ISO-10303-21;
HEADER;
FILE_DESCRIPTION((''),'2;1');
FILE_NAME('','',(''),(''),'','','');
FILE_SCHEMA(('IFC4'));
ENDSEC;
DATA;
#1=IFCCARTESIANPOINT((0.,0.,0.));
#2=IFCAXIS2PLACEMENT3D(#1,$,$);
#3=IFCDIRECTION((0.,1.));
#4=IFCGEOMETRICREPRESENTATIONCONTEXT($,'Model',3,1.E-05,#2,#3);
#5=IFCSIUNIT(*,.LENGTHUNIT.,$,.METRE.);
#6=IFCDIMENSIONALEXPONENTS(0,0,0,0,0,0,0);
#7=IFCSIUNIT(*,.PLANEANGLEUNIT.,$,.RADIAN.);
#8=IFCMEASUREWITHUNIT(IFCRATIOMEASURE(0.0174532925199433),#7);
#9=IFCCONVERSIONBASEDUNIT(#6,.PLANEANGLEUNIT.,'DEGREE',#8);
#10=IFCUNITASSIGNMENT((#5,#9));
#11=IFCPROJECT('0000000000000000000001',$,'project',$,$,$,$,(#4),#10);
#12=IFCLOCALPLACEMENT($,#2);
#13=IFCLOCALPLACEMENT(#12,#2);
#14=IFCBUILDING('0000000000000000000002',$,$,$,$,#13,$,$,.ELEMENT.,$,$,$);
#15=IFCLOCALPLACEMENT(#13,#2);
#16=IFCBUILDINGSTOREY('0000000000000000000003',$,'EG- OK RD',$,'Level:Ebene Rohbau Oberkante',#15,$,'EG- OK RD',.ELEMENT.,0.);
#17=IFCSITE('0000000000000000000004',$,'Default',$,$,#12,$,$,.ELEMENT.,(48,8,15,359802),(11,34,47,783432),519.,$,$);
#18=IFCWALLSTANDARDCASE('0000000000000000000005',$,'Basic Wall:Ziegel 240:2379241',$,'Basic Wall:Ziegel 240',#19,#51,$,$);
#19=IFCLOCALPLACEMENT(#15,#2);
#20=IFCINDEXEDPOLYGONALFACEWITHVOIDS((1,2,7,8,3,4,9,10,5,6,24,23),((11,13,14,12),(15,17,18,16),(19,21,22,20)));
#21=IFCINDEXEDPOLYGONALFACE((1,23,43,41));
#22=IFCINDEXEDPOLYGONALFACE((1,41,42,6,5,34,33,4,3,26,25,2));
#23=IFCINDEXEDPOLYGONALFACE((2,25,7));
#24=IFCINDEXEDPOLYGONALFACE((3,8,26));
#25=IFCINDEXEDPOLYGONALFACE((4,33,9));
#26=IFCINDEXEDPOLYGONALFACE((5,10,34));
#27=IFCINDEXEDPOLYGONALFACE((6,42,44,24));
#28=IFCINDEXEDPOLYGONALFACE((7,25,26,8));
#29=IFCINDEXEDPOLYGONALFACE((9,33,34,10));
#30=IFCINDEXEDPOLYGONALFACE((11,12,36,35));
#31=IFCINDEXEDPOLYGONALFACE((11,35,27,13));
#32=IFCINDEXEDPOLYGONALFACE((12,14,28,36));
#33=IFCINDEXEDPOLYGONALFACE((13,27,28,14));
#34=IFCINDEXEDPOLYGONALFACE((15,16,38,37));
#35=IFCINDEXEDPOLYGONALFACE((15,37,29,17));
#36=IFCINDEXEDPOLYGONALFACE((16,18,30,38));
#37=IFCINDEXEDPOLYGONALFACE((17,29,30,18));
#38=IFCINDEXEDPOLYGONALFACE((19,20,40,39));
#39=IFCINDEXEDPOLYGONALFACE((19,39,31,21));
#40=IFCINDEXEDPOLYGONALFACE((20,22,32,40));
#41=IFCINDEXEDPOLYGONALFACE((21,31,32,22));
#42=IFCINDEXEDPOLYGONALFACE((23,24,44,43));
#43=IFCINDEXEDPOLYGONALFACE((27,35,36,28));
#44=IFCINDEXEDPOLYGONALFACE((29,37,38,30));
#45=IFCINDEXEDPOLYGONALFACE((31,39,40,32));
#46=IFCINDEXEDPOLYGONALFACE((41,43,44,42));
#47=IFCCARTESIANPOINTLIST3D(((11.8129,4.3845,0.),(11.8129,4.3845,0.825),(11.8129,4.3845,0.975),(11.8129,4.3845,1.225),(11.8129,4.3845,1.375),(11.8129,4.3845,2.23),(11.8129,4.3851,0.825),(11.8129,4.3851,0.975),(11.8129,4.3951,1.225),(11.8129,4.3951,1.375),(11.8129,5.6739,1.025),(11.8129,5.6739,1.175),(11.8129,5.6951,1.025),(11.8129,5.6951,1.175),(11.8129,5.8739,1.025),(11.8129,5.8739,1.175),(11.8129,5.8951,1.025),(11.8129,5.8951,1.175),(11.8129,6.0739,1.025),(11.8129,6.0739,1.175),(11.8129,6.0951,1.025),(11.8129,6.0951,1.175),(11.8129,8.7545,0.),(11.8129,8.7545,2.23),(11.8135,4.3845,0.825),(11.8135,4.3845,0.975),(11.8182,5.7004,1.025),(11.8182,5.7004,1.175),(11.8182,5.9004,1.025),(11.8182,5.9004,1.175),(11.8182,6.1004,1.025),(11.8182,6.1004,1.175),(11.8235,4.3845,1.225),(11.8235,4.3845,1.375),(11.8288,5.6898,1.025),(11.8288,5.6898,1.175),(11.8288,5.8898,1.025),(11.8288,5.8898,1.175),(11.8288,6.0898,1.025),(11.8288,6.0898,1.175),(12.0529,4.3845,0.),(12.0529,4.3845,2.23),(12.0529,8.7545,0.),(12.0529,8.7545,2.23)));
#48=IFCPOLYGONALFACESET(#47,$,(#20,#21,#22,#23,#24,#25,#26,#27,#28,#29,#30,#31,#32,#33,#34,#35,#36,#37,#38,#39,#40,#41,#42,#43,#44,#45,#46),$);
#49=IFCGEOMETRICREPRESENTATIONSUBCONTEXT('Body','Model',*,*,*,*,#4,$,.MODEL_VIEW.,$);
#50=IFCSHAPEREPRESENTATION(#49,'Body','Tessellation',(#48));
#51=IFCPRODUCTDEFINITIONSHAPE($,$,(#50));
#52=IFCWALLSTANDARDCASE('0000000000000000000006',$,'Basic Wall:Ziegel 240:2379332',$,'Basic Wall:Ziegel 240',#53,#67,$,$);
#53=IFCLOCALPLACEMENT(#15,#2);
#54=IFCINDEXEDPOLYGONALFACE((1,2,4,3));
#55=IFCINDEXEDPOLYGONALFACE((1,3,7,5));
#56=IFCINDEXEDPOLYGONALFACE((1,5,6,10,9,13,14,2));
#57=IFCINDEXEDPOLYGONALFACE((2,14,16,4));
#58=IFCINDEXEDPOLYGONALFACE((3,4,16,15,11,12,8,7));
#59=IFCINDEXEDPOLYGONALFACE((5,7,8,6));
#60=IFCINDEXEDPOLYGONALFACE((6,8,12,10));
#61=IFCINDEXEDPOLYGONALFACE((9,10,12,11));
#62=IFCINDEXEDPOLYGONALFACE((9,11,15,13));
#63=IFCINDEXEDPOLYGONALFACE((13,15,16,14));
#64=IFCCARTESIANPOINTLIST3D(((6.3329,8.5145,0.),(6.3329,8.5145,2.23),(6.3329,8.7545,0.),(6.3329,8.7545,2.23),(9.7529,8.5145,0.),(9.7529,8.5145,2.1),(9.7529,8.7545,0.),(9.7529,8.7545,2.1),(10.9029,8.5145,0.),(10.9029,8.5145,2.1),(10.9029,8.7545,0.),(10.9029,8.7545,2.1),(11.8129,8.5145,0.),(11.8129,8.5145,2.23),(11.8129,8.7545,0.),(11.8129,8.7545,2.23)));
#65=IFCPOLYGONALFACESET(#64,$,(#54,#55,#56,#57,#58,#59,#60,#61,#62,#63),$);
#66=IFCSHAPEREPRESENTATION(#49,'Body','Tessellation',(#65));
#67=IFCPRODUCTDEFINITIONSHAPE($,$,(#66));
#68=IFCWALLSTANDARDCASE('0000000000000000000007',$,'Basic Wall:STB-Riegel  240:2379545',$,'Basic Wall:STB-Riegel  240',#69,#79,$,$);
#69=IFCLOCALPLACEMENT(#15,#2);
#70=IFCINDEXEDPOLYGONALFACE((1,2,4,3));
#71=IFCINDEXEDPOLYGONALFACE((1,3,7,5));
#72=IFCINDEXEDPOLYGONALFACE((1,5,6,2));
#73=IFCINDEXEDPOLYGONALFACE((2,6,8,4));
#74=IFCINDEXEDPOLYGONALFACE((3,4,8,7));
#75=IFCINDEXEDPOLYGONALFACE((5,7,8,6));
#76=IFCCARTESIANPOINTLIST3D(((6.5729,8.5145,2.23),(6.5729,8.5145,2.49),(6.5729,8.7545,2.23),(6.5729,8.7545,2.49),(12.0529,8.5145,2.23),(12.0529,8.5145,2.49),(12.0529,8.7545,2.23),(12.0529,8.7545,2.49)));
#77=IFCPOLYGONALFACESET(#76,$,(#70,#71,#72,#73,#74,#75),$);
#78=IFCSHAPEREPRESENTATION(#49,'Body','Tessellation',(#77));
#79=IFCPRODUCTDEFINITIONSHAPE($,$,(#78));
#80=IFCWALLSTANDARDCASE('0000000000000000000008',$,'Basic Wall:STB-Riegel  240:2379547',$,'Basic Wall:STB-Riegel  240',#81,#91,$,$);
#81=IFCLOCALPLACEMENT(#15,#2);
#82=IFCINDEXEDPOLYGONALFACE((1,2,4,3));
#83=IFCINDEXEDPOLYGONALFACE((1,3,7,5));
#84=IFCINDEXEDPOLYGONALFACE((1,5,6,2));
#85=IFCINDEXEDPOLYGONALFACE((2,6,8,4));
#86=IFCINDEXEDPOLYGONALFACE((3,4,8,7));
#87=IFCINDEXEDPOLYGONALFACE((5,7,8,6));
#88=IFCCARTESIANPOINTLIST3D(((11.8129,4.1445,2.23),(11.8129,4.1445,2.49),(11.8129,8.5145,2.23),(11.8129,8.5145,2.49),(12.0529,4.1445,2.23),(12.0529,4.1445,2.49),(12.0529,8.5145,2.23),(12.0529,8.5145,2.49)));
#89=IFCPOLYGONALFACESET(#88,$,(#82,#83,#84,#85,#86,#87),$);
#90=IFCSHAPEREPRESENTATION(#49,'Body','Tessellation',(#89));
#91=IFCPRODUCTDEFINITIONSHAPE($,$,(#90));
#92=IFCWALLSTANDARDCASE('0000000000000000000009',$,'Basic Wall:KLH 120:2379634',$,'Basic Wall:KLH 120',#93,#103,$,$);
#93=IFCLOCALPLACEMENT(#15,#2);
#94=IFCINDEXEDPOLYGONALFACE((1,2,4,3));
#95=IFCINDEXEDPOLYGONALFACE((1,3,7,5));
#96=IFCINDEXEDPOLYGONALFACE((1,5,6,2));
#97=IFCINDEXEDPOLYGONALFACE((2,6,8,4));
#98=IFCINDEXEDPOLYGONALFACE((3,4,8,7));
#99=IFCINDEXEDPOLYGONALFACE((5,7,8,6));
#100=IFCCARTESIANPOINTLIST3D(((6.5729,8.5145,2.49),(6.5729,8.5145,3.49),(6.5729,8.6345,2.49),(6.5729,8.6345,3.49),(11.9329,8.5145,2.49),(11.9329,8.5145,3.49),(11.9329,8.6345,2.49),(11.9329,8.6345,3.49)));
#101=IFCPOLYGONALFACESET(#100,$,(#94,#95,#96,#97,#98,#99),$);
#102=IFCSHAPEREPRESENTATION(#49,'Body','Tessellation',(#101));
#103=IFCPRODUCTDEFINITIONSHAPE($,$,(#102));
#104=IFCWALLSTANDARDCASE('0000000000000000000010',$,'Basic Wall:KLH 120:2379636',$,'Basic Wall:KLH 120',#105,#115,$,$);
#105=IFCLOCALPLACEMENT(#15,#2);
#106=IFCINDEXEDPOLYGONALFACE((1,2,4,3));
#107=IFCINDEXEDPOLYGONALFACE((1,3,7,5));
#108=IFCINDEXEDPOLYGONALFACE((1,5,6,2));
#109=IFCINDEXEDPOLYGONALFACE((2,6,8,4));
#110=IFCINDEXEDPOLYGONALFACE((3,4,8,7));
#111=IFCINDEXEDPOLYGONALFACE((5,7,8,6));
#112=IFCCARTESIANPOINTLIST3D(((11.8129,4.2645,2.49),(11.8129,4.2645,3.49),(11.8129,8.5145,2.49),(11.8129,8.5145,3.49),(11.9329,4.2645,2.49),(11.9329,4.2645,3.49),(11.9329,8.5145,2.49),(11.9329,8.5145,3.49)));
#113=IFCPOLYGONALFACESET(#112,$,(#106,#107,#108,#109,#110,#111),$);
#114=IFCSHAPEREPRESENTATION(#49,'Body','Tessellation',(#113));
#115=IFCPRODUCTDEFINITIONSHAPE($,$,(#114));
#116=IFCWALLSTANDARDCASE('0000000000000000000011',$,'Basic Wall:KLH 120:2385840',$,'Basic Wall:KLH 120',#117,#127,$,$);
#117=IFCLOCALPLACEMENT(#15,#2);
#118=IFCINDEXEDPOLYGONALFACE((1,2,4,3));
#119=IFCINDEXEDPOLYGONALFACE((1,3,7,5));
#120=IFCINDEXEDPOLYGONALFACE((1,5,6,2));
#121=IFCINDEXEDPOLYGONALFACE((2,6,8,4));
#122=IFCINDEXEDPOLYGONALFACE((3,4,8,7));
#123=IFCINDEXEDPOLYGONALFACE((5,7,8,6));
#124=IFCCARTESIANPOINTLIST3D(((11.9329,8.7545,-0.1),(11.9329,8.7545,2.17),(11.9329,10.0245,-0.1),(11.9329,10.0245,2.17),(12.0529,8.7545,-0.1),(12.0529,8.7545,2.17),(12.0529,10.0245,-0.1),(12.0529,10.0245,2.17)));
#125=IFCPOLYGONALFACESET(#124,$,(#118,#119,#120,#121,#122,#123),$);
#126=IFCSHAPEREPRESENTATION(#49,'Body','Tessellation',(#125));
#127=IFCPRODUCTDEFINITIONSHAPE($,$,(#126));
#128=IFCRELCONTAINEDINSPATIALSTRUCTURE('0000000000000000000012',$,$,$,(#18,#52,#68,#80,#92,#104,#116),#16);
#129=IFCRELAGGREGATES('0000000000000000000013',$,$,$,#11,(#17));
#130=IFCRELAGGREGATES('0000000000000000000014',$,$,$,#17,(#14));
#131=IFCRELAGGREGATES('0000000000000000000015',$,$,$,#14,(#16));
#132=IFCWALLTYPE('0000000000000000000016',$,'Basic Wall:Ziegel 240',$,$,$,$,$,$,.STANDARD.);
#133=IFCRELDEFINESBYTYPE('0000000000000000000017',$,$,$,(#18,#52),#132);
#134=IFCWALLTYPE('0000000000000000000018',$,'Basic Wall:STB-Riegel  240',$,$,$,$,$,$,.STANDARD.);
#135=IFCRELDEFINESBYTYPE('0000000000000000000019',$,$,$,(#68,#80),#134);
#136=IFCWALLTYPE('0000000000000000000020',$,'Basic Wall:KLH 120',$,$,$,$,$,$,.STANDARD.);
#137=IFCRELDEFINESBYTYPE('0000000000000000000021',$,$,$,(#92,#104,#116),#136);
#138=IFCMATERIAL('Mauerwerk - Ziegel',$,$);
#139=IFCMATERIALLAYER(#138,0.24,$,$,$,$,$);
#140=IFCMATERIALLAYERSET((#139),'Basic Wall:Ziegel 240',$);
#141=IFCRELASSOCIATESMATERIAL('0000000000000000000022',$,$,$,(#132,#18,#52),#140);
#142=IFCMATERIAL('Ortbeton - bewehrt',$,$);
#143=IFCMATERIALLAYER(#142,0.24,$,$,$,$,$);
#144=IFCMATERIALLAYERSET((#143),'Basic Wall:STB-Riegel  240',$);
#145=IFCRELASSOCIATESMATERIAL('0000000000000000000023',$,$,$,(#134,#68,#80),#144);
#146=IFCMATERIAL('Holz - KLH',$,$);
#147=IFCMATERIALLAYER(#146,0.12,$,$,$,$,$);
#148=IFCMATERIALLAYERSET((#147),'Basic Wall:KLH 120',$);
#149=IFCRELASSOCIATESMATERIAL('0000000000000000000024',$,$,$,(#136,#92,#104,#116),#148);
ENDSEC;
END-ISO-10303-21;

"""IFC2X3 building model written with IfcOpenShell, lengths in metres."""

from ifc_helpers import new_model, entity, si_unit, converted_unit, direction, frame, frame_2d, origin, place, context, subcontext, project, spatial, polyline, rectangle, extrude, clip, bounded_halfspace, material, layer, layer_set, layer_usage, type_object, element, save


model = new_model("IFC2X3")

# Units and contexts
model_context = context("Model", 3, precision=1e-05, world=origin(), true_north=direction((0.0, 1.0)))
body_context = subcontext(model_context, "Body", "Model", "MODEL_VIEW")
ifc_project = project(units=[si_unit("LENGTHUNIT", "METRE"), converted_unit("PLANEANGLEUNIT", "DEGREE", entity("IfcRatioMeasure", 0.0174532925199433), si_unit("PLANEANGLEUNIT", "RADIAN"), dimensions=[0, 0, 0, 0, 0, 0, 0])], contexts=[model_context])

# Site, building, storey
site_placement = place(None, origin())
site = spatial("IfcSite", under=ifc_project, at=site_placement, Name="Default", CompositionType="ELEMENT", RefLatitude=(48, 8, 15, 359802), RefLongitude=(11, 34, 47, 783432), RefElevation=519.0)
building_placement = place(site_placement, origin())
building = spatial("IfcBuilding", under=site, at=building_placement, CompositionType="ELEMENT")
storey_placement = place(building_placement, origin())
storey = spatial("IfcBuildingStorey", under=building, at=storey_placement, Name="EG- OK RD", ObjectType="Level:Ebene Rohbau Oberkante", LongName="EG- OK RD", CompositionType="ELEMENT", Elevation=0.0)

# Wall, openings
ifc_material_1 = material(Name="Mauerwerk - Ziegel")
ifc_layer_1 = layer(ifc_material_1, 0.24)
ifc_layer_set_1 = layer_set([ifc_layer_1], Name="Basic Wall:Ziegel 240")
ifc_layer_usage_1 = layer_usage(ifc_layer_set_1, "AXIS2", "POSITIVE", -0.12)
wall_type_1 = type_object("IfcWallType", Name="Basic Wall:Ziegel 240", PredefinedType="STANDARD", material=ifc_layer_set_1)
wall_1_placement = place(storey_placement, frame((11.9329, 4.3845, 0.0), z_axis=(0.0, 0.0, 1.0), x_axis=(0.0, 1.0, 0.0)))
wall_1 = element("IfcWallStandardCase", 1, at=wall_1_placement, inside=storey, type_object=wall_type_1, material=ifc_layer_usage_1, Name="Basic Wall:Ziegel 240:2379241", ObjectType="Basic Wall:Ziegel 240", context=body_context, shape_type="SweptSolid", body=[
    extrude(rectangle(XDim=4.37, YDim=0.24, at=frame_2d((2.185, 0.0), x_axis=(-1.0, 0.0))), origin(), (0.0, 0.0, 1.0), 2.23),
])
opening_1_placement = place(wall_1_placement, origin())
element("IfcOpeningElement", 2, at=opening_1_placement, cuts=wall_1, ObjectType="Recess", context=body_context, shape_type="SweptSolid", body=[
    extrude(rectangle(XDim=0.15, YDim=0.0285, at=frame_2d((0.0, 0.0), x_axis=(0.0, 1.0))), frame((0.0048, 0.1242, 0.9), z_axis=(-0.707107, 0.707107, 0.0), x_axis=(-0.707107, -0.707107, 0.0)), (0.0, 0.0, 1.0), 0.015),
])
opening_2_placement = place(wall_1_placement, origin())
element("IfcOpeningElement", 3, at=opening_2_placement, cuts=wall_1, ObjectType="Recess", context=body_context, shape_type="SweptSolid", body=[
    extrude(rectangle(XDim=0.15, YDim=0.0285, at=frame_2d((0.0, 0.0), x_axis=(0.0, 1.0))), frame((0.0048, 0.1142, 1.3), z_axis=(-0.707107, 0.707107, 0.0), x_axis=(-0.707107, -0.707107, 0.0)), (0.0, 0.0, 1.0), 0.015),
])
opening_3_placement = place(wall_1_placement, origin())
element("IfcOpeningElement", 4, at=opening_3_placement, cuts=wall_1, ObjectType="Recess", context=body_context, shape_type="SweptSolid", body=[
    extrude(rectangle(XDim=0.15, YDim=0.0285, at=frame_2d((0.0, 0.0), x_axis=(0.0, 1.0))), frame((0.1195, 0.2289, 1.1), z_axis=(-0.707107, 0.707107, 0.0), x_axis=(-0.707107, -0.707107, 0.0)), (0.0, 0.0, 1.0), 0.015),
])
opening_4_placement = place(wall_1_placement, origin())
element("IfcOpeningElement", 5, at=opening_4_placement, cuts=wall_1, ObjectType="Recess", context=body_context, shape_type="SweptSolid", body=[
    extrude(rectangle(XDim=0.15, YDim=0.0285, at=frame_2d((0.0, 0.0), x_axis=(0.0, 1.0))), frame((1.2952, 0.1142, 1.1), z_axis=(0.707107, 0.707107, 0.0), x_axis=(0.707107, -0.707107, 0.0)), (0.0, 0.0, 1.0), 0.015),
])
opening_5_placement = place(wall_1_placement, origin())
element("IfcOpeningElement", 6, at=opening_5_placement, cuts=wall_1, ObjectType="Recess", context=body_context, shape_type="SweptSolid", body=[
    extrude(rectangle(XDim=0.15, YDim=0.0285, at=frame_2d((0.0, 0.0), x_axis=(0.0, 1.0))), frame((1.4952, 0.1142, 1.1), z_axis=(0.707107, 0.707107, 0.0), x_axis=(0.707107, -0.707107, 0.0)), (0.0, 0.0, 1.0), 0.015),
])
opening_6_placement = place(wall_1_placement, origin())
element("IfcOpeningElement", 7, at=opening_6_placement, cuts=wall_1, ObjectType="Recess", context=body_context, shape_type="SweptSolid", body=[
    extrude(rectangle(XDim=0.15, YDim=0.0285, at=frame_2d((0.0, 0.0), x_axis=(0.0, 1.0))), frame((1.6952, 0.1142, 1.1), z_axis=(0.707107, 0.707107, 0.0), x_axis=(0.707107, -0.707107, 0.0)), (0.0, 0.0, 1.0), 0.015),
])

# Wall, opening
ifc_layer_usage_2 = layer_usage(ifc_layer_set_1, "AXIS2", "POSITIVE", -0.12)
wall_2_placement = place(storey_placement, frame((11.8129, 8.6345, 0.0), z_axis=(0.0, 0.0, 1.0), x_axis=(-1.0, 0.0, 0.0)))
wall_2 = element("IfcWallStandardCase", 8, at=wall_2_placement, inside=storey, type_object=wall_type_1, material=ifc_layer_usage_2, Name="Basic Wall:Ziegel 240:2379332", ObjectType="Basic Wall:Ziegel 240", context=body_context, shape_type="SweptSolid", body=[
    extrude(rectangle(XDim=5.48, YDim=0.24, at=frame_2d((2.74, 0.0), x_axis=(-1.0, 0.0))), origin(), (0.0, 0.0, 1.0), 2.23),
])
opening_7_placement = place(wall_2_placement, frame((0.91, -0.12, 0.0)))
element("IfcOpeningElement", 9, at=opening_7_placement, cuts=wall_2, ObjectType="Opening", context=body_context, shape_type="SweptSolid", body=[
    extrude(rectangle(XDim=2.1, YDim=1.15, at=frame_2d((1.05, 0.575), x_axis=(-1.0, 0.0))), frame((0.0, 0.0, 0.0), z_axis=(0.0, 1.0, 0.0), x_axis=(0.0, 0.0, 1.0)), (0.0, 0.0, 1.0), 0.24),
])

# Walls
ifc_material_2 = material(Name="Ortbeton - bewehrt")
ifc_layer_2 = layer(ifc_material_2, 0.24)
ifc_layer_set_2 = layer_set([ifc_layer_2], Name="Basic Wall:STB-Riegel  240")
ifc_layer_usage_3 = layer_usage(ifc_layer_set_2, "AXIS2", "NEGATIVE", 0.12)
wall_type_2 = type_object("IfcWallType", Name="Basic Wall:STB-Riegel  240", PredefinedType="STANDARD", material=ifc_layer_set_2)
wall_3_placement = place(storey_placement, frame((12.0529, 8.6345, 2.23), z_axis=(0.0, 0.0, 1.0), x_axis=(-1.0, 0.0, 0.0)))
element("IfcWallStandardCase", 10, at=wall_3_placement, inside=storey, type_object=wall_type_2, material=ifc_layer_usage_3, Name="Basic Wall:STB-Riegel  240:2379545", ObjectType="Basic Wall:STB-Riegel  240", context=body_context, shape_type="SweptSolid", body=[
    extrude(rectangle(XDim=5.48, YDim=0.24, at=frame_2d((2.74, 0.0), x_axis=(-1.0, 0.0))), origin(), (0.0, 0.0, 1.0), 0.26),
])
ifc_layer_usage_4 = layer_usage(ifc_layer_set_2, "AXIS2", "NEGATIVE", 0.12)
wall_4_placement = place(storey_placement, frame((11.9329, 4.1445, 2.23), z_axis=(0.0, 0.0, 1.0), x_axis=(0.0, 1.0, 0.0)))
element("IfcWallStandardCase", 11, at=wall_4_placement, inside=storey, type_object=wall_type_2, material=ifc_layer_usage_4, Name="Basic Wall:STB-Riegel  240:2379547", ObjectType="Basic Wall:STB-Riegel  240", context=body_context, shape_type="SweptSolid", body=[
    extrude(rectangle(XDim=4.37, YDim=0.24, at=frame_2d((2.185, 0.0), x_axis=(-1.0, 0.0))), origin(), (0.0, 0.0, 1.0), 0.26),
])
ifc_material_3 = material(Name="Holz - KLH")
ifc_layer_3 = layer(ifc_material_3, 0.12)
ifc_layer_set_3 = layer_set([ifc_layer_3], Name="Basic Wall:KLH 120")
ifc_layer_usage_5 = layer_usage(ifc_layer_set_3, "AXIS2", "NEGATIVE", 0.06)
wall_type_3 = type_object("IfcWallType", Name="Basic Wall:KLH 120", PredefinedType="STANDARD", material=ifc_layer_set_3)
wall_5_placement = place(storey_placement, frame((11.9329, 8.5745, 2.49), z_axis=(0.0, 0.0, 1.0), x_axis=(-1.0, 0.0, 0.0)))
element("IfcWallStandardCase", 12, at=wall_5_placement, inside=storey, type_object=wall_type_3, material=ifc_layer_usage_5, Name="Basic Wall:KLH 120:2379634", ObjectType="Basic Wall:KLH 120", context=body_context, shape_type="SweptSolid", body=[
    extrude(rectangle(XDim=5.36, YDim=0.12, at=frame_2d((2.68, 0.0), x_axis=(-1.0, 0.0))), origin(), (0.0, 0.0, 1.0), 1.0),
])
ifc_layer_usage_6 = layer_usage(ifc_layer_set_3, "AXIS2", "NEGATIVE", 0.06)
wall_6_placement = place(storey_placement, frame((11.8729, 4.2645, 2.49), z_axis=(0.0, 0.0, 1.0), x_axis=(0.0, 1.0, 0.0)))
element("IfcWallStandardCase", 13, at=wall_6_placement, inside=storey, type_object=wall_type_3, material=ifc_layer_usage_6, Name="Basic Wall:KLH 120:2379636", ObjectType="Basic Wall:KLH 120", context=body_context, shape_type="SweptSolid", body=[
    extrude(rectangle(XDim=4.25, YDim=0.12, at=frame_2d((2.125, 0.0), x_axis=(-1.0, 0.0))), origin(), (0.0, 0.0, 1.0), 1.0),
])
ifc_layer_usage_7 = layer_usage(ifc_layer_set_3, "AXIS2", "POSITIVE", -0.06)
wall_7_placement = place(storey_placement, frame((11.9929, 8.7545, -0.1), z_axis=(0.0, 0.0, 1.0), x_axis=(0.0, 1.0, 0.0)))
element("IfcWallStandardCase", 14, at=wall_7_placement, inside=storey, type_object=wall_type_3, material=ifc_layer_usage_7, Name="Basic Wall:KLH 120:2385840", ObjectType="Basic Wall:KLH 120", context=body_context, shape_type="Clipping", body=[
    clip(extrude(rectangle(XDim=1.27, YDim=0.12, at=frame_2d((0.635, 0.0), x_axis=(-1.0, 0.0))), origin(), (0.0, 0.0, 1.0), 2.27), bounded_halfspace(frame((0.0, -0.06, 2.27), z_axis=(0.0, 0.0, -1.0), x_axis=(-1.0, 0.0, 0.0)), True, frame((0.0, -0.06, 2.27)), polyline([(0.0, 0.0), (1.27, 0.0), (1.27, 0.12), (0.0, 0.12), (0.0, 0.0)]))),
])

save(model, "model.ifc")
